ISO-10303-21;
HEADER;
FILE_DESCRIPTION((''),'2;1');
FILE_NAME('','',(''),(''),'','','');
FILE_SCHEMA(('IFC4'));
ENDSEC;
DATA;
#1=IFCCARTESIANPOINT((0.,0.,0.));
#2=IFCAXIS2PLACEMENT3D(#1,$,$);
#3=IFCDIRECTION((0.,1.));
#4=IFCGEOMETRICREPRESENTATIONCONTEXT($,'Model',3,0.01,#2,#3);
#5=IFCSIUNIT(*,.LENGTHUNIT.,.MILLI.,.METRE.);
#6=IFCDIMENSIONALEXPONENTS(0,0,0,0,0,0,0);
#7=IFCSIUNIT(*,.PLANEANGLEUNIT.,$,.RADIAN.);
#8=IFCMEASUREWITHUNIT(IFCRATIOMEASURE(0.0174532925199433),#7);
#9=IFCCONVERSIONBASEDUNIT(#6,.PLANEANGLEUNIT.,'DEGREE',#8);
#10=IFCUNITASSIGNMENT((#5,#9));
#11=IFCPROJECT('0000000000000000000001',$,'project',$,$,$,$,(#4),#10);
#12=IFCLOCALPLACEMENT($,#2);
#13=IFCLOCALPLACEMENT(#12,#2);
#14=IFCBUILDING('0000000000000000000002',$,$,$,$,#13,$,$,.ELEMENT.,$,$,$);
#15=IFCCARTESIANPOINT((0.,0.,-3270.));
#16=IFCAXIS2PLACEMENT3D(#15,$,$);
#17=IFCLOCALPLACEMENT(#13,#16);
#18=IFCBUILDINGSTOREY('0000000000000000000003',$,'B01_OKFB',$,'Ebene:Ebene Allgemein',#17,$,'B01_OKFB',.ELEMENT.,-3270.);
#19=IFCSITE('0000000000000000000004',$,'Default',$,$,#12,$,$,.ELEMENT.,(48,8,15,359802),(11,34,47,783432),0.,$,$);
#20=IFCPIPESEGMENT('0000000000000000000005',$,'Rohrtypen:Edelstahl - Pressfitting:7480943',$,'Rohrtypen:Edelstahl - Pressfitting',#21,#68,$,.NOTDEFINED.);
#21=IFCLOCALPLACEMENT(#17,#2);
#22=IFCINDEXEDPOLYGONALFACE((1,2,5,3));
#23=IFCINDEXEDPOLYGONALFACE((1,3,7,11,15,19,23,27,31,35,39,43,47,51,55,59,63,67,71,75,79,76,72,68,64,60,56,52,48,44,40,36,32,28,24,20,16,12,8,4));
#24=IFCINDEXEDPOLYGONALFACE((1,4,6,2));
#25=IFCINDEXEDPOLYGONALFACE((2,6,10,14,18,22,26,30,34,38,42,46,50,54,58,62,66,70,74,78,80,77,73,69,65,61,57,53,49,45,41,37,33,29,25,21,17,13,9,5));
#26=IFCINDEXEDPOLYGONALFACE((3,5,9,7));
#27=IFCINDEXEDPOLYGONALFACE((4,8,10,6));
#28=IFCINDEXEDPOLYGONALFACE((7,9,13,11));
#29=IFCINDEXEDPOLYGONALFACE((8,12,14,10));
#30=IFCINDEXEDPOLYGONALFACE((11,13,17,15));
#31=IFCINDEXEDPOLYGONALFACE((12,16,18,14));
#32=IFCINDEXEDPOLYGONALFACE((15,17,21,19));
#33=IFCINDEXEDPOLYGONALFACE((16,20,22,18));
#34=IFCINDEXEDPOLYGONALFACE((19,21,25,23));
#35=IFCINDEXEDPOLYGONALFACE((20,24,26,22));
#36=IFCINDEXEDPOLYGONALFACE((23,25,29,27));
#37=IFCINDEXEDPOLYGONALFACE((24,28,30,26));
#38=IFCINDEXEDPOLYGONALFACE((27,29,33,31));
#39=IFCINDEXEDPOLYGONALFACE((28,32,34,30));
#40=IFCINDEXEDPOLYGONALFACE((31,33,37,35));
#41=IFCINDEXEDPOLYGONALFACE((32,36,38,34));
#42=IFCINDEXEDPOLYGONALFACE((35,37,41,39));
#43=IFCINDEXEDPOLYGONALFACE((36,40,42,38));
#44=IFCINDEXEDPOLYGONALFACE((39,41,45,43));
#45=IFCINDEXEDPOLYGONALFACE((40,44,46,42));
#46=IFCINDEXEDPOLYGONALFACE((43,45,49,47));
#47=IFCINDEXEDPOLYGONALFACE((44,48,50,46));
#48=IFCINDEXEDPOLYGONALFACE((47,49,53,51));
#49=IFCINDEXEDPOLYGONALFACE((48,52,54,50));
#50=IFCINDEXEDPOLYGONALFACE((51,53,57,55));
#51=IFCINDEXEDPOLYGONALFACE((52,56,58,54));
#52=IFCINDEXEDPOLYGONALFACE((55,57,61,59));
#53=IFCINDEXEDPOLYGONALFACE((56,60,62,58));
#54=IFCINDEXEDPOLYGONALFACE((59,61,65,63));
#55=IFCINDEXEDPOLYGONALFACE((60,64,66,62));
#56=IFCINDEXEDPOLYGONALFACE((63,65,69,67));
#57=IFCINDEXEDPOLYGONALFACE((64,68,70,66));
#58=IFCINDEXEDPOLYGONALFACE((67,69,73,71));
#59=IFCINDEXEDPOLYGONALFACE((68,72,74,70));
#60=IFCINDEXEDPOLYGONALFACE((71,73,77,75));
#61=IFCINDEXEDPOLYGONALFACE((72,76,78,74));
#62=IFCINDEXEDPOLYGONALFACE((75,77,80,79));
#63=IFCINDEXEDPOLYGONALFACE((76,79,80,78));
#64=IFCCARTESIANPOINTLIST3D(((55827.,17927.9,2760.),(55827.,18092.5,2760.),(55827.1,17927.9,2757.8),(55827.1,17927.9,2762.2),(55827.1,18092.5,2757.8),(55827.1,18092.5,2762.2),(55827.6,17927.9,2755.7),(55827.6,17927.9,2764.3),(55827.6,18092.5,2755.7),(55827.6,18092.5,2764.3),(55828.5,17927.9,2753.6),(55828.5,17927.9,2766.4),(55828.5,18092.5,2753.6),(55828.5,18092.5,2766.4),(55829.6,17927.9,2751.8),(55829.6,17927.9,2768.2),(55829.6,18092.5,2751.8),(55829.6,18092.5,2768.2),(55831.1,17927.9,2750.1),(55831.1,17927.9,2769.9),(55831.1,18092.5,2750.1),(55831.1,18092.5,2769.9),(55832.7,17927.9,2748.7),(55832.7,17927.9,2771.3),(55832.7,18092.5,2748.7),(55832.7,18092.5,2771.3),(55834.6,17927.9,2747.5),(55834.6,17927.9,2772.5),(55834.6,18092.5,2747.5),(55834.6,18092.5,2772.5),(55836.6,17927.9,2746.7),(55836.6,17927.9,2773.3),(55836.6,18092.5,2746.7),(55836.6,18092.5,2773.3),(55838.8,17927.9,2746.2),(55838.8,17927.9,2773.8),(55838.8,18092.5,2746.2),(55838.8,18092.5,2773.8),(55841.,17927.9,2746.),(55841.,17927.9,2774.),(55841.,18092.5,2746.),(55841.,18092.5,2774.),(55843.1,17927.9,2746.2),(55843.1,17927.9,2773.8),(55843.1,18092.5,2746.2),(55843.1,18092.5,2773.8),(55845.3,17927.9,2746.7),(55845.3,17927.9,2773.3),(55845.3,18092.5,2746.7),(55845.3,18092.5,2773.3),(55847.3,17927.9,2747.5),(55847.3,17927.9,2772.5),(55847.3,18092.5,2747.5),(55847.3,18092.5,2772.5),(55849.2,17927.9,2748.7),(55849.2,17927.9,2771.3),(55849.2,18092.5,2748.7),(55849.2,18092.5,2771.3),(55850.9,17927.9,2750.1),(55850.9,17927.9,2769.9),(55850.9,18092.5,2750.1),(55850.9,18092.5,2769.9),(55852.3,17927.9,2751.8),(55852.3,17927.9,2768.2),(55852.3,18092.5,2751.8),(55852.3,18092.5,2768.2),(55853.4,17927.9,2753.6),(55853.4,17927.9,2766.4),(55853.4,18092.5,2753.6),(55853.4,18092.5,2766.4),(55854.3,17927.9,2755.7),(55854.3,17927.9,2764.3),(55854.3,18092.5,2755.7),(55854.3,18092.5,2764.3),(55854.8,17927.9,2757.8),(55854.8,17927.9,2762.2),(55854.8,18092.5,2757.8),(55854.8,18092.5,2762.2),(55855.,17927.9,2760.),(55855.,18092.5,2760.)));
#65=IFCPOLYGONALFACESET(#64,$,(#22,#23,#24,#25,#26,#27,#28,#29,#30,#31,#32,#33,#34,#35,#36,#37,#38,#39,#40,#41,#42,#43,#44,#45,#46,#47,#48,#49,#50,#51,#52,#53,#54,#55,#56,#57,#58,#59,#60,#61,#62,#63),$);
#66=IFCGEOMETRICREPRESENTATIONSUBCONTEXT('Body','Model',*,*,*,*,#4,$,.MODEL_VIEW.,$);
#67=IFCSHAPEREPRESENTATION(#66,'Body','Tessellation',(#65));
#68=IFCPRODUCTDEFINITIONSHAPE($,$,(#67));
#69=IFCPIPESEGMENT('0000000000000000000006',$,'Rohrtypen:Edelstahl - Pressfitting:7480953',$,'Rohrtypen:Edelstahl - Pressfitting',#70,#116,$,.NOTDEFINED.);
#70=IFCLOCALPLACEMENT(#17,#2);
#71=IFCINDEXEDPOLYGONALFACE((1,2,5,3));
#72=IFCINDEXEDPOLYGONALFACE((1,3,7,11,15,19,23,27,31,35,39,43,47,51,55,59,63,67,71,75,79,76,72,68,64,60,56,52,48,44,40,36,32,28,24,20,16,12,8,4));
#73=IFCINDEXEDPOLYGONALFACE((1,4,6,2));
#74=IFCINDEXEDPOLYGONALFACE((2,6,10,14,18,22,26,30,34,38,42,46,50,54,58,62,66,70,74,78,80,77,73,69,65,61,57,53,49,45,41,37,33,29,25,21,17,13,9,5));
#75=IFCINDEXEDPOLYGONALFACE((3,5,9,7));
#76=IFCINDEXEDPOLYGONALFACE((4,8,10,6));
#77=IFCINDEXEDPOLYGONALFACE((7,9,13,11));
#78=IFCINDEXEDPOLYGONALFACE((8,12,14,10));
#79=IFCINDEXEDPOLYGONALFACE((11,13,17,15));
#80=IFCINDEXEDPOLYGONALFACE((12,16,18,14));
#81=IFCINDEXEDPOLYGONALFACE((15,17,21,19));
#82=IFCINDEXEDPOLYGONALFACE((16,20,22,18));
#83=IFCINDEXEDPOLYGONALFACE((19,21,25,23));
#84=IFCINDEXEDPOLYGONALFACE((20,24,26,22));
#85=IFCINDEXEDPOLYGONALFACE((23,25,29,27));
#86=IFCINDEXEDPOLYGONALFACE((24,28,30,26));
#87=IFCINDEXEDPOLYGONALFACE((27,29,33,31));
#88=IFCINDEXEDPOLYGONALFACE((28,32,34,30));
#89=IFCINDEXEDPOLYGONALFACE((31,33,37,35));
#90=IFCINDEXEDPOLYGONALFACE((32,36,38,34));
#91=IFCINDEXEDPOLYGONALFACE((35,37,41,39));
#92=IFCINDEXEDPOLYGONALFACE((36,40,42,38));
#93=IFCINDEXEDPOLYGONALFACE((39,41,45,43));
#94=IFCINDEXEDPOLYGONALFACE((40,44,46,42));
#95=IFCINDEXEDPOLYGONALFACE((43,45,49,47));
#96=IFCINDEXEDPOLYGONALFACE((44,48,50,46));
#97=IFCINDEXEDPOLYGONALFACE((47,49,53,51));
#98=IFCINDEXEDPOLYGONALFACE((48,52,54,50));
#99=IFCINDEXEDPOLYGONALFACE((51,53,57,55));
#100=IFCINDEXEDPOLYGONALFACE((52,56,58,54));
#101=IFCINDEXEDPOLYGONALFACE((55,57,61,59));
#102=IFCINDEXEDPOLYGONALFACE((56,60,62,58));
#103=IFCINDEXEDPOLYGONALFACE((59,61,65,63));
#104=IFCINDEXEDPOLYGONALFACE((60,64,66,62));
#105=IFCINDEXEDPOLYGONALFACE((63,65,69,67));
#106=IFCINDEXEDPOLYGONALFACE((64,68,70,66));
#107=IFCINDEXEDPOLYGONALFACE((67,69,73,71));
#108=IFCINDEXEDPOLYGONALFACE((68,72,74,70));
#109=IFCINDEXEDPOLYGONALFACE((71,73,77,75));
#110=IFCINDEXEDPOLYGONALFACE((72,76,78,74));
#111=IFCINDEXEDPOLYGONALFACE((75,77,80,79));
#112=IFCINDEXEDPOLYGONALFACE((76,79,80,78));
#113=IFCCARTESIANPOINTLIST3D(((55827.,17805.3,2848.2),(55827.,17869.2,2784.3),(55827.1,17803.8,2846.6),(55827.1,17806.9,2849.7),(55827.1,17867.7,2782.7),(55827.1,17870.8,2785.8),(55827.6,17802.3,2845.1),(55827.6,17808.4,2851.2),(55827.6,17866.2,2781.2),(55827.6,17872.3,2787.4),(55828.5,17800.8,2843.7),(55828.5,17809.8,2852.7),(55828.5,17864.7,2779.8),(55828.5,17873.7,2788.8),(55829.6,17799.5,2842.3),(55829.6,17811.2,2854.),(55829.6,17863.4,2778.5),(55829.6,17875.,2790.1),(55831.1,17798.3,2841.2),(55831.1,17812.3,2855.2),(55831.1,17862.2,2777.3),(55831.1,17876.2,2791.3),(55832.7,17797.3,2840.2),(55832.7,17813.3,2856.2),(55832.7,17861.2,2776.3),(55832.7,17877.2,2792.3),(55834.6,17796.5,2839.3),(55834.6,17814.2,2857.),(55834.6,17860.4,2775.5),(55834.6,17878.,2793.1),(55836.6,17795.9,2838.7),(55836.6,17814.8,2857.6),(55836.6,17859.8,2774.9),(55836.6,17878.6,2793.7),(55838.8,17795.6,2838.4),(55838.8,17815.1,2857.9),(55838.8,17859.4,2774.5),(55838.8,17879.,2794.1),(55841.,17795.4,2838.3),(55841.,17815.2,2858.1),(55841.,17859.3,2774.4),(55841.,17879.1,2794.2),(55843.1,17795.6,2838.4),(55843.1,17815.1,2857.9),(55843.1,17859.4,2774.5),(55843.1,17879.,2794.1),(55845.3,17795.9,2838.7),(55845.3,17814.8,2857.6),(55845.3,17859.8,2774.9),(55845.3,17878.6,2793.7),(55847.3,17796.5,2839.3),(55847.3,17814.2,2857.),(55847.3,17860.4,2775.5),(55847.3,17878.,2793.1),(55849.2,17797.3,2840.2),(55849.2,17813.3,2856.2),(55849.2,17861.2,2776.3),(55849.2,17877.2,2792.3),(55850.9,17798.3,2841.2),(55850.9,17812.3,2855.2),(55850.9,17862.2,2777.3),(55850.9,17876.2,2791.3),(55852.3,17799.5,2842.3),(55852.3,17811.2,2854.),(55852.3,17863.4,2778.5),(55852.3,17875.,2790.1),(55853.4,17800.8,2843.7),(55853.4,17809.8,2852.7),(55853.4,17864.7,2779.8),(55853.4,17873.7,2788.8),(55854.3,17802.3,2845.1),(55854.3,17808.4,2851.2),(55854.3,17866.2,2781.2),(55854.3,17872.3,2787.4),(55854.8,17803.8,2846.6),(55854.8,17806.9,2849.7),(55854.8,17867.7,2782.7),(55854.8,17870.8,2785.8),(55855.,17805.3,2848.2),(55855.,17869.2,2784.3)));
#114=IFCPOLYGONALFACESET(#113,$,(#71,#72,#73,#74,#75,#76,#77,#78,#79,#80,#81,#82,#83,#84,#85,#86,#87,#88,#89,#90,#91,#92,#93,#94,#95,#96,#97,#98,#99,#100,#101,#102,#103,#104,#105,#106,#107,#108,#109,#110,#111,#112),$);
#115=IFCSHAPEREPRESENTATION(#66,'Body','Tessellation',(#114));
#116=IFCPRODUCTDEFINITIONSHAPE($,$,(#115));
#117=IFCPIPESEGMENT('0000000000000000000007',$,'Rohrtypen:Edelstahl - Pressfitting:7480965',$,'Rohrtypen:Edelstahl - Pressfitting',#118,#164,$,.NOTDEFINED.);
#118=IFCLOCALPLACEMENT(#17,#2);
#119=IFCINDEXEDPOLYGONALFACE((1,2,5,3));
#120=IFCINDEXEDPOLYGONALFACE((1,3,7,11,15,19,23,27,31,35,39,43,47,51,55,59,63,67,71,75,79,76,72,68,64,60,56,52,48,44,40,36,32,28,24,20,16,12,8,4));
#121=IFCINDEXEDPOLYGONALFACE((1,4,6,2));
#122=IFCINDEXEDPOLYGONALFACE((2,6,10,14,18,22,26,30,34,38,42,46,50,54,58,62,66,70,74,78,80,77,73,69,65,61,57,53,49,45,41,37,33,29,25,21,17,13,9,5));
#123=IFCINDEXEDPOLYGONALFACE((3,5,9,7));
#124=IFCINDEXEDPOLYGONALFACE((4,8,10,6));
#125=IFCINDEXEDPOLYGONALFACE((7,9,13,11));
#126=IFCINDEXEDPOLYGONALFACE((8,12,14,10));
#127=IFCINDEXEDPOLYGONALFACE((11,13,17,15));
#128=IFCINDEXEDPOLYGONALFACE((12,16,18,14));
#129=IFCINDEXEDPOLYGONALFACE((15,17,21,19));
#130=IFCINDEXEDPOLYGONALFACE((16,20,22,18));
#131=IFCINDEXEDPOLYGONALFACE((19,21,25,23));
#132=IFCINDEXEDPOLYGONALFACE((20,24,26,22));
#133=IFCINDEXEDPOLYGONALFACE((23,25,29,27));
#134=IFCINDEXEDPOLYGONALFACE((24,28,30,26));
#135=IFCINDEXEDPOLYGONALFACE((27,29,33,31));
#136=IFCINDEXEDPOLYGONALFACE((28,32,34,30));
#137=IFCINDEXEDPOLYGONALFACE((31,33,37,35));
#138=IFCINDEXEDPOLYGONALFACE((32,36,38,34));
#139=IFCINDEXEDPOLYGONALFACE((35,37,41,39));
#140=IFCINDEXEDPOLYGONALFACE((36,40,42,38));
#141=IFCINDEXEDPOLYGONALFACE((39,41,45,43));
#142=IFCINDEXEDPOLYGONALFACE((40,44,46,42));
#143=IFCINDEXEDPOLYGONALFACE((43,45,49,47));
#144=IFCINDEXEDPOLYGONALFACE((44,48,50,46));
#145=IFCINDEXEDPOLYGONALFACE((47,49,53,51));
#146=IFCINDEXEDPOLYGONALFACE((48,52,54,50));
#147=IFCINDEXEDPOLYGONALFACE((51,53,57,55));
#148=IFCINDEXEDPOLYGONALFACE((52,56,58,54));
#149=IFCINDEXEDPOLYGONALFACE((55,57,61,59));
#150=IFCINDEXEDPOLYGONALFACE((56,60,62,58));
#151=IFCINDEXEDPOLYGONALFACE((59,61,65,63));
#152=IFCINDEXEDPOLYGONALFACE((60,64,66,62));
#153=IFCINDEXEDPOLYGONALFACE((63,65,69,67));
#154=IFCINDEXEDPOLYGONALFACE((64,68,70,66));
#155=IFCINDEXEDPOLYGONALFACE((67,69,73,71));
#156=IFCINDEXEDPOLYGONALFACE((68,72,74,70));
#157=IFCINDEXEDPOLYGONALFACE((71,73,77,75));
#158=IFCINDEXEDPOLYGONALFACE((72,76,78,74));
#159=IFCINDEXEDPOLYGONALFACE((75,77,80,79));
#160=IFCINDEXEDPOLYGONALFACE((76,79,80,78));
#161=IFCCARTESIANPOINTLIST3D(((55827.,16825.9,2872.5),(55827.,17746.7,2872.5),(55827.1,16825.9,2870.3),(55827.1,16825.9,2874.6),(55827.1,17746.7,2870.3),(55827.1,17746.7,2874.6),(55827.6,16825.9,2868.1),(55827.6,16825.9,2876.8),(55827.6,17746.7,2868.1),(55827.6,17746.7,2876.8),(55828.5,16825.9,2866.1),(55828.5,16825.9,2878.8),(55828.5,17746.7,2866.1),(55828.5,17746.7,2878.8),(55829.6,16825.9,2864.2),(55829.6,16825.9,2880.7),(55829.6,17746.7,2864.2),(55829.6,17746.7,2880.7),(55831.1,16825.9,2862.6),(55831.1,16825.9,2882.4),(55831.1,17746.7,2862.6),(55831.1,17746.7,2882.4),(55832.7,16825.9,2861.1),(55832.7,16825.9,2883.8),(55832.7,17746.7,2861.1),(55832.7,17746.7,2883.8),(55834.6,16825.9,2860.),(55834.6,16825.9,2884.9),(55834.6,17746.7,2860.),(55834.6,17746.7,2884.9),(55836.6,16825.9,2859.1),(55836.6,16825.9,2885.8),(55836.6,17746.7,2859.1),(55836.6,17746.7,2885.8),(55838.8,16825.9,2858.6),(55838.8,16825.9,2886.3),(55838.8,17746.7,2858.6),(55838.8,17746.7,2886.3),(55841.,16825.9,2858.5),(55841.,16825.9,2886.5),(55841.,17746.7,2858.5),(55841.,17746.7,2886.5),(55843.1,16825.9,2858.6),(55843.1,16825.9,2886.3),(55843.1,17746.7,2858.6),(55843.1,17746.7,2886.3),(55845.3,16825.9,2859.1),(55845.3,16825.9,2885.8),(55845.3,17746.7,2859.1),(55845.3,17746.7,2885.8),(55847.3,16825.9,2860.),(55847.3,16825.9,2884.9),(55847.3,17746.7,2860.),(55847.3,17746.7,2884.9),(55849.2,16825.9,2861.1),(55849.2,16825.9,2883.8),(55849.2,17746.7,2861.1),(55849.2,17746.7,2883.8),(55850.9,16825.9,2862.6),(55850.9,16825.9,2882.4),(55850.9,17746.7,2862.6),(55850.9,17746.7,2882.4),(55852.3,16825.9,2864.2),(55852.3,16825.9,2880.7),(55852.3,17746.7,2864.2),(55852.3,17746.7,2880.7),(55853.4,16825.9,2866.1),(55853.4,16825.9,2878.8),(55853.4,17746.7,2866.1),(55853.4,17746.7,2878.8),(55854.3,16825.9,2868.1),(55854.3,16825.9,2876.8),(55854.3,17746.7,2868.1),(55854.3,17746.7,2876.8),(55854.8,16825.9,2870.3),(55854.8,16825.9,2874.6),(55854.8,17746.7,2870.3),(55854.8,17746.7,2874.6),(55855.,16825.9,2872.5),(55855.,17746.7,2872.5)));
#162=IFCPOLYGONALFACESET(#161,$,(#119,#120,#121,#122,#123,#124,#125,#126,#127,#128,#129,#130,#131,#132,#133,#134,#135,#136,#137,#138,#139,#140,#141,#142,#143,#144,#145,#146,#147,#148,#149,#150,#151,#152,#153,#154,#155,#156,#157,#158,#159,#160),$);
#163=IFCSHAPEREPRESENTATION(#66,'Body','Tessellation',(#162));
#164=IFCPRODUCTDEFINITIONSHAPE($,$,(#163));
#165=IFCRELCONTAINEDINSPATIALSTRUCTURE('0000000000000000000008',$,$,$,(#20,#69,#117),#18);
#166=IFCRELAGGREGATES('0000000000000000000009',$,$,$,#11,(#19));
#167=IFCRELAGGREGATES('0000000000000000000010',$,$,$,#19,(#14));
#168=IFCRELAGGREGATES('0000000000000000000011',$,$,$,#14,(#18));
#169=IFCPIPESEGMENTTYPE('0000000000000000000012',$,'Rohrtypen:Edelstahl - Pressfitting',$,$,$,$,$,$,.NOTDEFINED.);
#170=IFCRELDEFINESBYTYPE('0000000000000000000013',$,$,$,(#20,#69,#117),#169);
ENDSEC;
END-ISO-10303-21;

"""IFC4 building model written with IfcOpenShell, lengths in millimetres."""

from ifc_helpers import new_model, entity, si_unit, converted_unit, direction, frame, origin, place, context, subcontext, project, spatial, indexed_curve, outline, extrude, type_object, element, save


model = new_model("IFC4")

# Units and contexts
model_context = context("Model", 3, precision=0.01, world=origin(), true_north=direction((0.0, 1.0)))
body_context = subcontext(model_context, "Body", "Model", "MODEL_VIEW")
ifc_project = project(units=[si_unit("LENGTHUNIT", "METRE", prefix="MILLI"), converted_unit("PLANEANGLEUNIT", "DEGREE", entity("IfcRatioMeasure", 0.0174532925199433), si_unit("PLANEANGLEUNIT", "RADIAN"), dimensions=[0, 0, 0, 0, 0, 0, 0])], contexts=[model_context])

# Site, building, storey
site_placement = place(None, origin())
site = spatial("IfcSite", under=ifc_project, at=site_placement, Name="Default", CompositionType="ELEMENT", RefLatitude=(48, 8, 15, 359802), RefLongitude=(11, 34, 47, 783432), RefElevation=0.0)
building_placement = place(site_placement, origin())
building = spatial("IfcBuilding", under=site, at=building_placement, CompositionType="ELEMENT")
storey_placement = place(building_placement, frame((0.0, 0.0, -3270.0)))
storey = spatial("IfcBuildingStorey", under=building, at=storey_placement, Name="B01_OKFB", ObjectType="Ebene:Ebene Allgemein", LongName="B01_OKFB", CompositionType="ELEMENT", Elevation=-3270.0)

# Pipe segments
pipe_segment_type_1 = type_object("IfcPipeSegmentType", Name="Rohrtypen:Edelstahl - Pressfitting", PredefinedType="NOTDEFINED")
pipe_segment_1_placement = place(storey_placement, origin())
element("IfcPipeSegment", 1, at=pipe_segment_1_placement, inside=storey, type_object=pipe_segment_type_1, Name="Rohrtypen:Edelstahl - Pressfitting:7480943", ObjectType="Rohrtypen:Edelstahl - Pressfitting", PredefinedType="NOTDEFINED", context=body_context, shape_type="SweptSolid", body=[
    extrude(outline(indexed_curve([(14.0, 0.0), (13.8, 2.2), (13.3, 4.3), (12.5, 6.4), (11.3, 8.2), (9.9, 9.9), (8.2, 11.3), (6.4, 12.5), (4.3, 13.3), (2.2, 13.8), (0.0, 14.0), (-2.2, 13.8), (-4.3, 13.3), (-6.4, 12.5), (-8.2, 11.3), (-9.9, 9.9), (-11.3, 8.2), (-12.5, 6.4), (-13.3, 4.3), (-13.8, 2.2), (-14.0, 0.0), (-13.8, -2.2), (-13.3, -4.3), (-12.5, -6.4), (-11.3, -8.2), (-9.9, -9.9), (-8.2, -11.3), (-6.4, -12.5), (-4.3, -13.3), (-2.2, -13.8), (0.0, -14.0), (2.2, -13.8), (4.3, -13.3), (6.4, -12.5), (8.2, -11.3), (9.9, -9.9), (11.3, -8.2), (12.5, -6.4), (13.3, -4.3), (13.8, -2.2), (14.0, 0.0)], self_intersect=False)), frame((55841.0, 17927.9, 2760.0), z_axis=(0.0, 1.0, 0.0), x_axis=(-1.0, 0.0, 0.0)), (0.0, 0.0, 1.0), 164.6),
])
pipe_segment_2_placement = place(storey_placement, origin())
element("IfcPipeSegment", 2, at=pipe_segment_2_placement, inside=storey, type_object=pipe_segment_type_1, Name="Rohrtypen:Edelstahl - Pressfitting:7480953", ObjectType="Rohrtypen:Edelstahl - Pressfitting", PredefinedType="NOTDEFINED", context=body_context, shape_type="SweptSolid", body=[
    extrude(outline(indexed_curve([(14.0, 0.0), (13.8, 2.2), (13.3, 4.3), (12.5, 6.4), (11.3, 8.2), (9.9, 9.9), (8.2, 11.3), (6.4, 12.5), (4.3, 13.3), (2.2, 13.8), (0.0, 14.0), (-2.2, 13.8), (-4.3, 13.3), (-6.4, 12.5), (-8.2, 11.3), (-9.9, 9.9), (-11.3, 8.2), (-12.5, 6.4), (-13.3, 4.3), (-13.8, 2.2), (-14.0, 0.0), (-13.8, -2.2), (-13.3, -4.3), (-12.5, -6.4), (-11.3, -8.2), (-9.9, -9.9), (-8.2, -11.3), (-6.4, -12.5), (-4.3, -13.3), (-2.2, -13.8), (0.0, -14.0), (2.2, -13.8), (4.3, -13.3), (6.4, -12.5), (8.2, -11.3), (9.9, -9.9), (11.3, -8.2), (12.5, -6.4), (13.3, -4.3), (13.8, -2.2), (14.0, 0.0)], self_intersect=False)), frame((55841.0, 17869.2, 2784.3), z_axis=(0.0, -0.707107, 0.707107), x_axis=(-1.0, 0.0, 0.0)), (0.0, 0.0, 1.0), 90.3),
])
pipe_segment_3_placement = place(storey_placement, origin())
element("IfcPipeSegment", 3, at=pipe_segment_3_placement, inside=storey, type_object=pipe_segment_type_1, Name="Rohrtypen:Edelstahl - Pressfitting:7480965", ObjectType="Rohrtypen:Edelstahl - Pressfitting", PredefinedType="NOTDEFINED", context=body_context, shape_type="SweptSolid", body=[
    extrude(outline(indexed_curve([(14.0, 0.0), (13.8, 2.2), (13.3, 4.3), (12.5, 6.4), (11.3, 8.2), (9.9, 9.9), (8.2, 11.3), (6.4, 12.5), (4.3, 13.3), (2.2, 13.8), (0.0, 14.0), (-2.2, 13.8), (-4.3, 13.3), (-6.4, 12.5), (-8.2, 11.3), (-9.9, 9.9), (-11.3, 8.2), (-12.5, 6.4), (-13.3, 4.3), (-13.8, 2.2), (-14.0, 0.0), (-13.8, -2.2), (-13.3, -4.3), (-12.5, -6.4), (-11.3, -8.2), (-9.9, -9.9), (-8.2, -11.3), (-6.4, -12.5), (-4.3, -13.3), (-2.2, -13.8), (0.0, -14.0), (2.2, -13.8), (4.3, -13.3), (6.4, -12.5), (8.2, -11.3), (9.9, -9.9), (11.3, -8.2), (12.5, -6.4), (13.3, -4.3), (13.8, -2.2), (14.0, 0.0)], self_intersect=False)), frame((55841.0, 16825.9, 2872.5), z_axis=(0.0, 1.0, 0.0), x_axis=(1.0, 0.0, 0.0)), (0.0, 0.0, 1.0), 920.8),
])

save(model, "model.ifc")
